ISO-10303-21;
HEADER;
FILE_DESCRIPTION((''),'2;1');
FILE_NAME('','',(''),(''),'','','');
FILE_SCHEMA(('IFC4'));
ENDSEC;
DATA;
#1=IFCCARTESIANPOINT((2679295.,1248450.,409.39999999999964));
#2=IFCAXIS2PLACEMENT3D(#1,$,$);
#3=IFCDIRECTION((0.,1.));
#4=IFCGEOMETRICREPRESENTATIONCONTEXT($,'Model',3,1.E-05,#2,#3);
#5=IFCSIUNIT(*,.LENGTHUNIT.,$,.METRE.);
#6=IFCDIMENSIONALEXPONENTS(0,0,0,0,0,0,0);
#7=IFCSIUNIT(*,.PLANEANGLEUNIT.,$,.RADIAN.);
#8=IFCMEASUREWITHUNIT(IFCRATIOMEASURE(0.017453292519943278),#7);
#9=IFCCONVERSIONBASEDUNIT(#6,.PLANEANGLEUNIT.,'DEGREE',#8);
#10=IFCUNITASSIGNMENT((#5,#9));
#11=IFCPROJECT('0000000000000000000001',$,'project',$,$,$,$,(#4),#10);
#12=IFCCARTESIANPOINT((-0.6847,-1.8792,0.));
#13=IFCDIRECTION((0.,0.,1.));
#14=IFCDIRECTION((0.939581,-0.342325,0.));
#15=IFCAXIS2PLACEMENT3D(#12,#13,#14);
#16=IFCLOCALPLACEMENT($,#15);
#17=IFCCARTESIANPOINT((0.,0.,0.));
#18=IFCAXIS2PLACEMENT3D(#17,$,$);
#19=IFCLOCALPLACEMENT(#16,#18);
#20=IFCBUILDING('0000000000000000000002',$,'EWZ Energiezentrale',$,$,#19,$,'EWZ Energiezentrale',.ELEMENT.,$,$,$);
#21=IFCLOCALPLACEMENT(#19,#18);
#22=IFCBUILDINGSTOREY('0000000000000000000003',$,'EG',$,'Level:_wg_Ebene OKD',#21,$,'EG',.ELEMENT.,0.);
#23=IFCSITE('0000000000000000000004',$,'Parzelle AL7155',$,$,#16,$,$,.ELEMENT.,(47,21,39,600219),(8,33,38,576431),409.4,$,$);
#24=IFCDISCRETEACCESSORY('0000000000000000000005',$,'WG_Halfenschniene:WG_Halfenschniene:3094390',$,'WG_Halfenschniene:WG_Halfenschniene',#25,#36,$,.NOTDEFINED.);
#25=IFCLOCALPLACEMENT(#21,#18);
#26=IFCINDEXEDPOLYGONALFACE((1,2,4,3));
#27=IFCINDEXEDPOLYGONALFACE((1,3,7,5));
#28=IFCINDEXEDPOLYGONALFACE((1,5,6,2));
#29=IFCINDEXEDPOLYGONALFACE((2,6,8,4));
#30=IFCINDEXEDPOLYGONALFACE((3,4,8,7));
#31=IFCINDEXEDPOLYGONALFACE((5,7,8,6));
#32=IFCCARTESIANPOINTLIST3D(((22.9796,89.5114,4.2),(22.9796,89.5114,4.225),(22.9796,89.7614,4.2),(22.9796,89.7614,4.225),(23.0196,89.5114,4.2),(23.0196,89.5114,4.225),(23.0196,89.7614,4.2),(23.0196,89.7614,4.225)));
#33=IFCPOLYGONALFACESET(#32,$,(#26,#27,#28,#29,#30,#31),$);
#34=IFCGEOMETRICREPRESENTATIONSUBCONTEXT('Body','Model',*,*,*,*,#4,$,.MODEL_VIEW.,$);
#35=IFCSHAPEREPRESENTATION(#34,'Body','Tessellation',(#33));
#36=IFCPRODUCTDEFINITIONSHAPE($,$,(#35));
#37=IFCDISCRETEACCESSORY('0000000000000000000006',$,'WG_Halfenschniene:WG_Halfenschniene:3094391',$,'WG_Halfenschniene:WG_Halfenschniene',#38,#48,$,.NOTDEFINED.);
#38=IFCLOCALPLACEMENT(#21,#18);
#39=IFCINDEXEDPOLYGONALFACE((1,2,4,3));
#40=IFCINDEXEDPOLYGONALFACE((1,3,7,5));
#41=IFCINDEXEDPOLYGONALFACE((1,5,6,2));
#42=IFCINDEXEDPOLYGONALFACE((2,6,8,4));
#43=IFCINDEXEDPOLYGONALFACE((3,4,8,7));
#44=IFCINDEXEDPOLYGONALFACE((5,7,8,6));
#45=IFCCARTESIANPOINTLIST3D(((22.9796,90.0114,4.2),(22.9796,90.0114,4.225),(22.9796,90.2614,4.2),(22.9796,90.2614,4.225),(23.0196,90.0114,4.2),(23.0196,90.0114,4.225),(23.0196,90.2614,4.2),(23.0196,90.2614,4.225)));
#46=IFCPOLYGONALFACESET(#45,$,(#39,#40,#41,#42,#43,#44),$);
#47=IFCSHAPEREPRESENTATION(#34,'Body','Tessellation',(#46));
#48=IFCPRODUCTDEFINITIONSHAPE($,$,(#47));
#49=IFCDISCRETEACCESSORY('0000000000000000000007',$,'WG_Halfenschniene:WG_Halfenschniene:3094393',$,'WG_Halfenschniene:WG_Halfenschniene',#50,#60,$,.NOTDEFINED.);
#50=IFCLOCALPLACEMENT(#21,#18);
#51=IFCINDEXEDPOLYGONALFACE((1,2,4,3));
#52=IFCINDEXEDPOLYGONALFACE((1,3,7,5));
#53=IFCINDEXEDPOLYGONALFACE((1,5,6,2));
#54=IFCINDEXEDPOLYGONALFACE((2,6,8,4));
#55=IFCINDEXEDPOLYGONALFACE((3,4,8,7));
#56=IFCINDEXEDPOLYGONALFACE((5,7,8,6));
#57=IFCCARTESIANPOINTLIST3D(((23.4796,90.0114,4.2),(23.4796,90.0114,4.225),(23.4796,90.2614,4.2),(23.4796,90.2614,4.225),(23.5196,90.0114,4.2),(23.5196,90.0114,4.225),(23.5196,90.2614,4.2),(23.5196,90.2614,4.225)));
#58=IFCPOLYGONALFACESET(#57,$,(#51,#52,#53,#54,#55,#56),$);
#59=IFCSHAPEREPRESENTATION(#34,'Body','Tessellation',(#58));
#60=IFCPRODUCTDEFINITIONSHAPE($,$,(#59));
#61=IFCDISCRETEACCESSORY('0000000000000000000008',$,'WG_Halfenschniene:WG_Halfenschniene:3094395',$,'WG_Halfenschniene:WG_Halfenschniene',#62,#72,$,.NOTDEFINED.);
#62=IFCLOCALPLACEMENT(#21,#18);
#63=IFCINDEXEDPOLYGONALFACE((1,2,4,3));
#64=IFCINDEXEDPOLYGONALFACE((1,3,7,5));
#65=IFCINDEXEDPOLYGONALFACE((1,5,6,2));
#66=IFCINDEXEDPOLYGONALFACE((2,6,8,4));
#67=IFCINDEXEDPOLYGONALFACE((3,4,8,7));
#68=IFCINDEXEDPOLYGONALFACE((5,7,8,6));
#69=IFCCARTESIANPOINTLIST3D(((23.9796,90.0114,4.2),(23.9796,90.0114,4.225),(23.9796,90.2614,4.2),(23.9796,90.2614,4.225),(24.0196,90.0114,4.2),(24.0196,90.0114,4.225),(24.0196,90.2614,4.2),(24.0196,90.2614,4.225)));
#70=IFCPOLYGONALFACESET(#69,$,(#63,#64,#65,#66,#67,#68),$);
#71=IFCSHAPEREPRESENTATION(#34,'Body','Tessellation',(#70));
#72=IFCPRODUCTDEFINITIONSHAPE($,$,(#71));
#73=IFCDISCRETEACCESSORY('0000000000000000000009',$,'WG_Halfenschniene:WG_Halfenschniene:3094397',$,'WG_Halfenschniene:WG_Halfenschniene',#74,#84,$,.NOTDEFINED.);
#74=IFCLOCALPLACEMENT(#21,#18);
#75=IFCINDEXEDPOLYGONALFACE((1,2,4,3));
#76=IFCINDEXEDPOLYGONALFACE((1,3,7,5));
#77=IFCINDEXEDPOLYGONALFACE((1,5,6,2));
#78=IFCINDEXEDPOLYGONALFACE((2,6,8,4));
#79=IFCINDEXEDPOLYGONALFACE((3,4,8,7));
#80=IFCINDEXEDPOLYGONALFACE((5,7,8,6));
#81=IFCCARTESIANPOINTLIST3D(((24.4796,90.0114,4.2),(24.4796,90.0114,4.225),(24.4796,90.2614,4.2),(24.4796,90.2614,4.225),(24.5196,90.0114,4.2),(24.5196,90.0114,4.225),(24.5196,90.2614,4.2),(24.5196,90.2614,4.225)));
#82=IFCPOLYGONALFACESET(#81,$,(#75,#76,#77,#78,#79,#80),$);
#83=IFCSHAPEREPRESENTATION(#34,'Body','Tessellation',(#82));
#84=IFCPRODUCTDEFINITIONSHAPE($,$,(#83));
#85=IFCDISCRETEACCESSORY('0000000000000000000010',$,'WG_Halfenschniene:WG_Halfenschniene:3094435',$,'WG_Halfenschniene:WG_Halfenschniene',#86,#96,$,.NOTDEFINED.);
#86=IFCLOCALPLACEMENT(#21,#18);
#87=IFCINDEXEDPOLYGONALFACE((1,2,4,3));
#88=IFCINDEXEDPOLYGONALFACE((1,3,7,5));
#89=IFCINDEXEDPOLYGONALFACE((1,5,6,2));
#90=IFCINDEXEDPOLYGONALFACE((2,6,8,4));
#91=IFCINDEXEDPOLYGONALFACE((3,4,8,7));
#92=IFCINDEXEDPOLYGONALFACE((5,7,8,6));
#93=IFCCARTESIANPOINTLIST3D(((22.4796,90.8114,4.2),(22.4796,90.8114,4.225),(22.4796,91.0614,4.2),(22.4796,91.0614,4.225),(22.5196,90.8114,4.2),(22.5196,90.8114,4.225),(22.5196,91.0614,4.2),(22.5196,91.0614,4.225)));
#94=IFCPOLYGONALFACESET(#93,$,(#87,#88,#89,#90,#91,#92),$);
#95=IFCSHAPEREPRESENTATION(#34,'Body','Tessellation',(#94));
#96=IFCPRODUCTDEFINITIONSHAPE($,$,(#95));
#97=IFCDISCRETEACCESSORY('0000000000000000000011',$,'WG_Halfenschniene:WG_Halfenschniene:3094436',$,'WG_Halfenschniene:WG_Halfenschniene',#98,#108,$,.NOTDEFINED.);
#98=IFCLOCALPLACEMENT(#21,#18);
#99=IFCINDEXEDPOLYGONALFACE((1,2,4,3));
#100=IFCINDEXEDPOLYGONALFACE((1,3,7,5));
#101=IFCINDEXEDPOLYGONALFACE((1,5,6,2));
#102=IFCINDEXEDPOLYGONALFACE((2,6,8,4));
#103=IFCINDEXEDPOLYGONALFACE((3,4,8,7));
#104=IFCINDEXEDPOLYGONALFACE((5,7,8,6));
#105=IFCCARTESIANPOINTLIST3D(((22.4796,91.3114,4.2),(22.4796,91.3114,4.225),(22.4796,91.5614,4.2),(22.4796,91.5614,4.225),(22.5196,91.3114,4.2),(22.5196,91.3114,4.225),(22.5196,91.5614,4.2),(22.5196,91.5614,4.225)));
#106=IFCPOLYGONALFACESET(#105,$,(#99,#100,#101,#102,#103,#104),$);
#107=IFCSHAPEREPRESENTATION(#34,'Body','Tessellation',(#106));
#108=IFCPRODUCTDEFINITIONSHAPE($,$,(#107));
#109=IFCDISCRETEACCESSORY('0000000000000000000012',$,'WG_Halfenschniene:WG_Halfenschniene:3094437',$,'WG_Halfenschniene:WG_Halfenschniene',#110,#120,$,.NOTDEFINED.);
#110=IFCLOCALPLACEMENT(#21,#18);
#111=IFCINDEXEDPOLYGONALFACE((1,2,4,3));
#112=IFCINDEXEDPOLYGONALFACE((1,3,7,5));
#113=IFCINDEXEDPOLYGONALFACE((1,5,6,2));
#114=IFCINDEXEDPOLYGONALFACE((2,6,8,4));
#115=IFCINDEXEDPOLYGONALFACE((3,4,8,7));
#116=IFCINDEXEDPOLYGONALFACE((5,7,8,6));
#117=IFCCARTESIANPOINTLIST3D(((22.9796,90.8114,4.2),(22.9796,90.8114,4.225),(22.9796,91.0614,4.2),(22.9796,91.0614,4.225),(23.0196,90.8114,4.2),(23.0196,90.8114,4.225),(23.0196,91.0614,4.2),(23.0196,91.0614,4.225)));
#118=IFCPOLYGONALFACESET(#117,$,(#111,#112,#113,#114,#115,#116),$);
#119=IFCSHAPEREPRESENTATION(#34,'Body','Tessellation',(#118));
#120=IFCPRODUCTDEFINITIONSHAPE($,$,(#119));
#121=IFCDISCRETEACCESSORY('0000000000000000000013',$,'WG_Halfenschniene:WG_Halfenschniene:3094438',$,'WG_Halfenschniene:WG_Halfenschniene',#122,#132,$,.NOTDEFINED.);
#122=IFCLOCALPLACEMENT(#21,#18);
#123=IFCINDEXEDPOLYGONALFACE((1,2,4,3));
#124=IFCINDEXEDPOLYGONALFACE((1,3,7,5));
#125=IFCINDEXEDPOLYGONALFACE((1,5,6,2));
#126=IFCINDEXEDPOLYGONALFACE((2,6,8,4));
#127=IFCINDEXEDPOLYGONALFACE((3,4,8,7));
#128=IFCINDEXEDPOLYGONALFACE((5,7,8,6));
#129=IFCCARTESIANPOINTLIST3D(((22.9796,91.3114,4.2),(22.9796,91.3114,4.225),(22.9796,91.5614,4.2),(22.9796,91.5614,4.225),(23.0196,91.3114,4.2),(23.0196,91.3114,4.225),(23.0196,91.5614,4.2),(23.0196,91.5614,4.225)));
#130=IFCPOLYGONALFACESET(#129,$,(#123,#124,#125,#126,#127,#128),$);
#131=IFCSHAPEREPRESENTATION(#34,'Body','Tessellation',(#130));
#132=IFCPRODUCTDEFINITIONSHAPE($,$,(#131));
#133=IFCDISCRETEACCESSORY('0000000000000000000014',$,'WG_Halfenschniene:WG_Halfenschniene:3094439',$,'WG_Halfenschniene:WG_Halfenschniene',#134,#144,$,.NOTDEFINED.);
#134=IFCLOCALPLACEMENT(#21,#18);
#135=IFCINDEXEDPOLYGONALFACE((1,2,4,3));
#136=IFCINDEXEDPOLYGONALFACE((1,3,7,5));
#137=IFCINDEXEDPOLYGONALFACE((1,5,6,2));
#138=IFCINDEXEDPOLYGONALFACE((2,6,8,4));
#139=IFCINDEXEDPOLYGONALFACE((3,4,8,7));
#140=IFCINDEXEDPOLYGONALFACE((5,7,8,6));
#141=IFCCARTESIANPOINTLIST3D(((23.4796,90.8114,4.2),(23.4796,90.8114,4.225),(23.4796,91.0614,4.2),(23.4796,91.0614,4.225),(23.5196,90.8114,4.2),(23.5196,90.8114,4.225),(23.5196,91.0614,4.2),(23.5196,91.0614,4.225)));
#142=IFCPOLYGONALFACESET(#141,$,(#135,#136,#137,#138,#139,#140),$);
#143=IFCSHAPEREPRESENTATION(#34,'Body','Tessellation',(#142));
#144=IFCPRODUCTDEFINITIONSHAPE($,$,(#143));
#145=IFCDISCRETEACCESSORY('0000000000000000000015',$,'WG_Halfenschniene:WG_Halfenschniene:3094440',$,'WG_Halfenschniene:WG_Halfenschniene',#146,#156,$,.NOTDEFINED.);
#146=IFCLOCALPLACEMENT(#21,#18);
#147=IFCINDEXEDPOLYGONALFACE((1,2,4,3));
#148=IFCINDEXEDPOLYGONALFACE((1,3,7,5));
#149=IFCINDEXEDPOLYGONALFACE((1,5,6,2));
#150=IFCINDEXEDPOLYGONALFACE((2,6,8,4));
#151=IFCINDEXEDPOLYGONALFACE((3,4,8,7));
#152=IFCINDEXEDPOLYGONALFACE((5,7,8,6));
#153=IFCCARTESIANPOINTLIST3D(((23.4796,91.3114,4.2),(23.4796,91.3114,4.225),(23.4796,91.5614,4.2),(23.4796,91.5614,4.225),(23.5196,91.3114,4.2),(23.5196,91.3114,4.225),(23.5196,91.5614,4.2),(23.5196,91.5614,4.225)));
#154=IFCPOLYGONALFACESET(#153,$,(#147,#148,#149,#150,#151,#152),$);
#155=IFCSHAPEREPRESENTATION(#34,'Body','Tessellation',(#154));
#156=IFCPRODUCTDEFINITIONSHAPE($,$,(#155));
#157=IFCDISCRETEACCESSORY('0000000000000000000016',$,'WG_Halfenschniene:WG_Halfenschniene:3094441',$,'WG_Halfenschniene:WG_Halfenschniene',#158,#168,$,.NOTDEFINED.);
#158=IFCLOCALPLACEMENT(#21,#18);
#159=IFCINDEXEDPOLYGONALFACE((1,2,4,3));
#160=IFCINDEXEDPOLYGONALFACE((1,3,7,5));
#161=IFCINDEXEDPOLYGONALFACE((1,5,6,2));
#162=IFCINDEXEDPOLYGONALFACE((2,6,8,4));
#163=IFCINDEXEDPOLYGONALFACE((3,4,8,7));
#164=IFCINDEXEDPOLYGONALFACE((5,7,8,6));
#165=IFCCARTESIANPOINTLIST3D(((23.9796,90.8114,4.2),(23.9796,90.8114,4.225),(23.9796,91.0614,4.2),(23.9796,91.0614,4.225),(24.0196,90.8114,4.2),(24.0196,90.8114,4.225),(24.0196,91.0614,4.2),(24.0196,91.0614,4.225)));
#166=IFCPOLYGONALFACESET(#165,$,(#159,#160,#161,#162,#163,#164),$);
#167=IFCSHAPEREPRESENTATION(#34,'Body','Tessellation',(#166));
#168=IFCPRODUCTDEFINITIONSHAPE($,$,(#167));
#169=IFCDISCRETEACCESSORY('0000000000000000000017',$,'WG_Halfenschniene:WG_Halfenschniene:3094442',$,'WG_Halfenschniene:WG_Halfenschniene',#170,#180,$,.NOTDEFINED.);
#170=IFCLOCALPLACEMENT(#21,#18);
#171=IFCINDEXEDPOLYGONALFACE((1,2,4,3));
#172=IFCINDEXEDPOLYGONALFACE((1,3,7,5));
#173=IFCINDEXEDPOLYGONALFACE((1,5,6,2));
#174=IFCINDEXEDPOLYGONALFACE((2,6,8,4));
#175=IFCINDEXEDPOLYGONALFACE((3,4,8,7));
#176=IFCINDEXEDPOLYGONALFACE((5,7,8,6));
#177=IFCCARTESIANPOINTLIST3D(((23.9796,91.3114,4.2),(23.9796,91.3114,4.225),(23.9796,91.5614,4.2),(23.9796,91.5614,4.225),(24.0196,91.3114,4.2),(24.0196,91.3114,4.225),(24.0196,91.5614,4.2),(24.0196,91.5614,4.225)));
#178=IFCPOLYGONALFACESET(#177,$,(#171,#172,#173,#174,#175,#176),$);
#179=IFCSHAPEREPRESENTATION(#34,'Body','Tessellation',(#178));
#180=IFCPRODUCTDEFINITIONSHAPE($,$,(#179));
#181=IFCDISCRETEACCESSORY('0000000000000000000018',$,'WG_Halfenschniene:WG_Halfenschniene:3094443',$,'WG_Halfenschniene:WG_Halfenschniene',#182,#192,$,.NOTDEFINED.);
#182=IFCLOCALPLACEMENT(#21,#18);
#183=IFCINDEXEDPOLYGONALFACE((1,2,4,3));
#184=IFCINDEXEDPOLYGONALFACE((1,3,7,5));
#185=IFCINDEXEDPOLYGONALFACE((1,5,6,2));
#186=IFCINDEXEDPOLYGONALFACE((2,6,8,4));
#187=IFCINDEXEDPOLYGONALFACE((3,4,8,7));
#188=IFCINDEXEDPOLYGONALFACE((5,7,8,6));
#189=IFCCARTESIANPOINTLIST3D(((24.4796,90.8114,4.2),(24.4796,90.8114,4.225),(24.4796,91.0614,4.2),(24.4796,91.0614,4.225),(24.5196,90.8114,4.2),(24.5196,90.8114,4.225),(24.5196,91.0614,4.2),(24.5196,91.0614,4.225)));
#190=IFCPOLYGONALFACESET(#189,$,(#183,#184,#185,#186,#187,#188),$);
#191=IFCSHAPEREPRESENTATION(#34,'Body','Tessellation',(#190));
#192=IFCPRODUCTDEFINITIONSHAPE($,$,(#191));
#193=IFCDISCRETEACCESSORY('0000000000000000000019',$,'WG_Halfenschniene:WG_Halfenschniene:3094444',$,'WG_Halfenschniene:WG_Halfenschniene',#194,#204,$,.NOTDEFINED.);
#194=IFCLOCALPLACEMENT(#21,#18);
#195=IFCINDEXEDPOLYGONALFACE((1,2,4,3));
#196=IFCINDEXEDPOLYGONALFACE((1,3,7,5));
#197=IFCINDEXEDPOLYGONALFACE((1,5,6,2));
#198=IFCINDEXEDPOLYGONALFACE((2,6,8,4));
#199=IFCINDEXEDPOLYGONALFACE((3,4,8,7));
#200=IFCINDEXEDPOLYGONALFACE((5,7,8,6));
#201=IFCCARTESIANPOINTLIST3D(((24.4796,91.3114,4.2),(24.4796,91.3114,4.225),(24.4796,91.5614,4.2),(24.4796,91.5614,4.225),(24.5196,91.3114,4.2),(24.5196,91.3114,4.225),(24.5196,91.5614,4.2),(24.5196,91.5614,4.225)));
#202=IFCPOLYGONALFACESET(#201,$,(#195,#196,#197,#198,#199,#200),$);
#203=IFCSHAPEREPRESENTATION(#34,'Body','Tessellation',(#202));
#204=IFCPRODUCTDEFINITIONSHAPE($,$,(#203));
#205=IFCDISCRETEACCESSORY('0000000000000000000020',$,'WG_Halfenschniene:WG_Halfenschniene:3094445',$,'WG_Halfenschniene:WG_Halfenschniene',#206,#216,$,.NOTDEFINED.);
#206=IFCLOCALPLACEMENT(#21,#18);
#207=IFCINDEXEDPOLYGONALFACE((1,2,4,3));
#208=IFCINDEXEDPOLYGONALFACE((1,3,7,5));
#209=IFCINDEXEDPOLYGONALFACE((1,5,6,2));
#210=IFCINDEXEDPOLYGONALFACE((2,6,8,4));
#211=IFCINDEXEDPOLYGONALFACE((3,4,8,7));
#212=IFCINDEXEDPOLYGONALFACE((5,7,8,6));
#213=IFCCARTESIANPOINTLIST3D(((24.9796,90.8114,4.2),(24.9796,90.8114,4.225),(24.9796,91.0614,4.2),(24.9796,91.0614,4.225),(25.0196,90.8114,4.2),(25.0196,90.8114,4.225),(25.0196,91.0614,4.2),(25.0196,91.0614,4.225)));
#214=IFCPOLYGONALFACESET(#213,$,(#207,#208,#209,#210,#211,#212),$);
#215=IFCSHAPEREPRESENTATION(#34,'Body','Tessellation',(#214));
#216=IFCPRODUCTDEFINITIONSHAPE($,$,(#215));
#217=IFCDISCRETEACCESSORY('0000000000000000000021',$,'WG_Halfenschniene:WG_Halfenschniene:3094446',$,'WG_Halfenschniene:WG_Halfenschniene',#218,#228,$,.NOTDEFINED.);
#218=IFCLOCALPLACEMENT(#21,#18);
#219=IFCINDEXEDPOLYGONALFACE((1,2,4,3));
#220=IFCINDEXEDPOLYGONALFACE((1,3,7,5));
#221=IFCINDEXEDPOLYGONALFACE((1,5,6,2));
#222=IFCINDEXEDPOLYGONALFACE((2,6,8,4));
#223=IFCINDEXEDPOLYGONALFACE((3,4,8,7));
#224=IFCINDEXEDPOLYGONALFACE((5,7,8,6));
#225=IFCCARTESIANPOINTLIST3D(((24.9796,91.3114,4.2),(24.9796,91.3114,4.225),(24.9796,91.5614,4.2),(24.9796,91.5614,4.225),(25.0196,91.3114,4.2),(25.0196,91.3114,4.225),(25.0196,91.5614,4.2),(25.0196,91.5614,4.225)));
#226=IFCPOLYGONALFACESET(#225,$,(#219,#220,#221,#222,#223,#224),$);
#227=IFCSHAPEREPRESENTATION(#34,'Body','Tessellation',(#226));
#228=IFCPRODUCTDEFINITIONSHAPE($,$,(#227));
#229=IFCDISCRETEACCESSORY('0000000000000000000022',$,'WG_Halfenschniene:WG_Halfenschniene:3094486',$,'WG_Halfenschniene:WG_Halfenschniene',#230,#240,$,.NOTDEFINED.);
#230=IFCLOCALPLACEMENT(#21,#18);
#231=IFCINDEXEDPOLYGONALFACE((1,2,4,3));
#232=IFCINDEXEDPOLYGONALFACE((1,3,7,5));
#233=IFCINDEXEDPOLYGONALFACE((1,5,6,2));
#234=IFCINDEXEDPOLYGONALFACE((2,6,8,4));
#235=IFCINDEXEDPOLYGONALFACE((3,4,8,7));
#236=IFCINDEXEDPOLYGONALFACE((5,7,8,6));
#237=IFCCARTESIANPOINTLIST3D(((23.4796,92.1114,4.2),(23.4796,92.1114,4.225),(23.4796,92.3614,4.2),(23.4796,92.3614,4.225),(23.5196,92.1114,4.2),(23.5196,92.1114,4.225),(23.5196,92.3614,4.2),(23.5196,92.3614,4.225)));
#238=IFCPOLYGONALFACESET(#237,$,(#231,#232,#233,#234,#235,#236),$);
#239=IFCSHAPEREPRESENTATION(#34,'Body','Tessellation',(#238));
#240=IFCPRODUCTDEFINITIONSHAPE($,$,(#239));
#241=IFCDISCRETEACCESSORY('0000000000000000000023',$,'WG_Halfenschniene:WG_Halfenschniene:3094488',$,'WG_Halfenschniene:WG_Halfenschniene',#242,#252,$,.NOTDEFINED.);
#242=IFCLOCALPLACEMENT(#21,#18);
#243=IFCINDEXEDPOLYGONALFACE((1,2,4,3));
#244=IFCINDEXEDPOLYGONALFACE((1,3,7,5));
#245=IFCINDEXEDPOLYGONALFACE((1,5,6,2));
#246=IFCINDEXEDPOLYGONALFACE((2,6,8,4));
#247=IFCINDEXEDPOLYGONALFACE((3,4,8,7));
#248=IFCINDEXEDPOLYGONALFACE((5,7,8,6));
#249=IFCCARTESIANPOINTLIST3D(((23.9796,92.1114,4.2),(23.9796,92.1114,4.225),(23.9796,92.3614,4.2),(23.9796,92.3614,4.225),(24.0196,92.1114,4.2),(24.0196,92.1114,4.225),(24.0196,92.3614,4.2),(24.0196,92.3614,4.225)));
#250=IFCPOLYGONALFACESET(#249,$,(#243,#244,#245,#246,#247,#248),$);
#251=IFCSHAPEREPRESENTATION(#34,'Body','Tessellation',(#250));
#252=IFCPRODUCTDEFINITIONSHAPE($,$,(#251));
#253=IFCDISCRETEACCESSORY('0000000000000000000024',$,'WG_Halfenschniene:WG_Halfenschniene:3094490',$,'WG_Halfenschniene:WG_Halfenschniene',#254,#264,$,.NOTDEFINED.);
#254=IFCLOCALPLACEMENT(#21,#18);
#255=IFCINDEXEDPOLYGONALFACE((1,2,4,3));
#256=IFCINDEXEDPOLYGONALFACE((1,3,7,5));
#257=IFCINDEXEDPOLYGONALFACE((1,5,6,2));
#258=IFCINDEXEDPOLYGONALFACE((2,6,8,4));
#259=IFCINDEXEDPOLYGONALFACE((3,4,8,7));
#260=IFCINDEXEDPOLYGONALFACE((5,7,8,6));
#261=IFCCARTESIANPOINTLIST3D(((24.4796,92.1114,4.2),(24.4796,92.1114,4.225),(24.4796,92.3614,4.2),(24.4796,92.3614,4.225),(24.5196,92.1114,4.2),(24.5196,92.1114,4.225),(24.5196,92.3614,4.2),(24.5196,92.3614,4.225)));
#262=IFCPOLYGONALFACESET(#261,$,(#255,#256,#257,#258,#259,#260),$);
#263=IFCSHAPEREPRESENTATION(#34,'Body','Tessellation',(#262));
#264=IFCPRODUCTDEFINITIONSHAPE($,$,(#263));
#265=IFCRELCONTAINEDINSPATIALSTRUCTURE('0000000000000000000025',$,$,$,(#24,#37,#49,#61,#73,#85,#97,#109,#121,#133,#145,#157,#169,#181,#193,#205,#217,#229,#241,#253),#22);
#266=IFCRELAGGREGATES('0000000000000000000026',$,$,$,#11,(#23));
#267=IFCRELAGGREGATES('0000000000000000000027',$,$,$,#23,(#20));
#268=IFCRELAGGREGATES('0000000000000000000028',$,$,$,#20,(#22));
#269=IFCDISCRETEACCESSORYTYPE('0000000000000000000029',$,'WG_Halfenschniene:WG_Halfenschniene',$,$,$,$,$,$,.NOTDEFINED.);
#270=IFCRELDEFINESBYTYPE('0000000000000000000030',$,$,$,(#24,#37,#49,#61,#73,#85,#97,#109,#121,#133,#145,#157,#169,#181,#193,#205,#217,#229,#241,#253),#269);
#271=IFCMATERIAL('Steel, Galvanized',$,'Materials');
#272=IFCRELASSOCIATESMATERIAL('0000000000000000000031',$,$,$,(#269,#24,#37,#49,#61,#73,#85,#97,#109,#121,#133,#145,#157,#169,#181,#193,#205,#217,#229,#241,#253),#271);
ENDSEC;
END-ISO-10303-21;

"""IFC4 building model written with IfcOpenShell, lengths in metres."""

from ifc_helpers import new_model, entity, si_unit, converted_unit, direction, frame, origin, place, context, subcontext, project, spatial, indexed_curve, outline, extrude, source, transform, mapped, material, type_object, element, save


model = new_model("IFC4")

# Units and contexts
model_context = context("Model", 3, precision=1e-05, world=frame((2679295.0, 1248450.0, 409.39999999999964)), true_north=direction((0.0, 1.0)))
body_context = subcontext(model_context, "Body", "Model", "MODEL_VIEW")
ifc_project = project(units=[si_unit("LENGTHUNIT", "METRE"), converted_unit("PLANEANGLEUNIT", "DEGREE", entity("IfcRatioMeasure", 0.017453292519943278), si_unit("PLANEANGLEUNIT", "RADIAN"), dimensions=[0, 0, 0, 0, 0, 0, 0])], contexts=[model_context])

# Site, building, storey
site_placement = place(None, frame((-0.6847, -1.8792, 0.0), z_axis=(0.0, 0.0, 1.0), x_axis=(0.939581, -0.342325, 0.0)))
site = spatial("IfcSite", under=ifc_project, at=site_placement, Name="Parzelle AL7155", CompositionType="ELEMENT", RefLatitude=(47, 21, 39, 600219), RefLongitude=(8, 33, 38, 576431), RefElevation=409.4)
building_placement = place(site_placement, origin())
building = spatial("IfcBuilding", under=site, at=building_placement, Name="EWZ Energiezentrale", LongName="EWZ Energiezentrale", CompositionType="ELEMENT")
storey_placement = place(building_placement, origin())
storey = spatial("IfcBuildingStorey", under=building, at=storey_placement, Name="EG", ObjectType="Level:_wg_Ebene OKD", LongName="EG", CompositionType="ELEMENT", Elevation=0.0)

# Discrete accessories
ifc_material = material(Name="Steel, Galvanized", Category="Materials")
discrete_accessory_type = type_object("IfcDiscreteAccessoryType", Name="WG_Halfenschniene:WG_Halfenschniene", PredefinedType="NOTDEFINED", material=ifc_material)
shared_shape = source(origin(), body_context, "Body", "SweptSolid", [
    extrude(outline(indexed_curve([(-0.125, -0.02), (0.125, -0.02), (0.125, 0.02), (-0.125, 0.02), (-0.125, -0.02)], self_intersect=False)), frame((0.125, 0.0, -0.0125)), (0.0, 0.0, 1.0), 0.025),
])
for number, where, z_axis, x_axis, name in (
    (1, (22.9996, 89.5114, 4.2125), (0.0, 0.0, -1.0), (0.0, 1.0, 0.0), "WG_Halfenschniene:WG_Halfenschniene:3094390"),
    (2, (22.9996, 90.0114, 4.2125), (0.0, 0.0, -1.0), (0.0, 1.0, 0.0), "WG_Halfenschniene:WG_Halfenschniene:3094391"),
    (3, (23.4996, 90.0114, 4.2125), (0.0, 0.0, -1.0), (0.0, 1.0, 0.0), "WG_Halfenschniene:WG_Halfenschniene:3094393"),
    (4, (23.9996, 90.0114, 4.2125), (0.0, 0.0, -1.0), (0.0, 1.0, 0.0), "WG_Halfenschniene:WG_Halfenschniene:3094395"),
    (5, (24.4996, 90.0114, 4.2125), (0.0, 0.0, -1.0), (0.0, 1.0, 0.0), "WG_Halfenschniene:WG_Halfenschniene:3094397"),
    (6, (22.4996, 90.8114, 4.2125), (0.0, 0.0, -1.0), (0.0, 1.0, 0.0), "WG_Halfenschniene:WG_Halfenschniene:3094435"),
    (7, (22.4996, 91.3114, 4.2125), (0.0, 0.0, -1.0), (0.0, 1.0, 0.0), "WG_Halfenschniene:WG_Halfenschniene:3094436"),
    (8, (22.9996, 90.8114, 4.2125), (0.0, 0.0, -1.0), (0.0, 1.0, 0.0), "WG_Halfenschniene:WG_Halfenschniene:3094437"),
    (9, (22.9996, 91.3114, 4.2125), (0.0, 0.0, -1.0), (0.0, 1.0, 0.0), "WG_Halfenschniene:WG_Halfenschniene:3094438"),
    (10, (23.4996, 90.8114, 4.2125), (0.0, 0.0, -1.0), (0.0, 1.0, 0.0), "WG_Halfenschniene:WG_Halfenschniene:3094439"),
    (11, (23.4996, 91.3114, 4.2125), (0.0, 0.0, -1.0), (0.0, 1.0, 0.0), "WG_Halfenschniene:WG_Halfenschniene:3094440"),
    (12, (23.9996, 90.8114, 4.2125), (0.0, 0.0, -1.0), (0.0, 1.0, 0.0), "WG_Halfenschniene:WG_Halfenschniene:3094441"),
    (13, (23.9996, 91.3114, 4.2125), (0.0, 0.0, -1.0), (0.0, 1.0, 0.0), "WG_Halfenschniene:WG_Halfenschniene:3094442"),
    (14, (24.4996, 90.8114, 4.2125), (0.0, 0.0, -1.0), (0.0, 1.0, 0.0), "WG_Halfenschniene:WG_Halfenschniene:3094443"),
    (15, (24.4996, 91.3114, 4.2125), (0.0, 0.0, -1.0), (0.0, 1.0, 0.0), "WG_Halfenschniene:WG_Halfenschniene:3094444"),
    (16, (24.9996, 90.8114, 4.2125), (0.0, 0.0, -1.0), (0.0, 1.0, 0.0), "WG_Halfenschniene:WG_Halfenschniene:3094445"),
    (17, (24.9996, 91.3114, 4.2125), (0.0, 0.0, -1.0), (0.0, 1.0, 0.0), "WG_Halfenschniene:WG_Halfenschniene:3094446"),
    (18, (23.4996, 92.1114, 4.2125), (0.0, 0.0, -1.0), (0.0, 1.0, 0.0), "WG_Halfenschniene:WG_Halfenschniene:3094486"),
    (19, (23.9996, 92.1114, 4.2125), (0.0, 0.0, -1.0), (0.0, 1.0, 0.0), "WG_Halfenschniene:WG_Halfenschniene:3094488"),
    (20, (24.4996, 92.1114, 4.2125), (0.0, 0.0, -1.0), (0.0, 1.0, 0.0), "WG_Halfenschniene:WG_Halfenschniene:3094490"),
):
    element("IfcDiscreteAccessory", number, at=place(storey_placement, frame(where, z_axis=z_axis, x_axis=x_axis)), inside=storey, type_object=discrete_accessory_type, material=ifc_material, Name=name, ObjectType="WG_Halfenschniene:WG_Halfenschniene", PredefinedType="NOTDEFINED", context=body_context, shape_type="MappedRepresentation", body=[
        mapped(shared_shape, transform((0.0, 0.0, 0.0), scale=1.0)),
    ])

save(model, "model.ifc")
